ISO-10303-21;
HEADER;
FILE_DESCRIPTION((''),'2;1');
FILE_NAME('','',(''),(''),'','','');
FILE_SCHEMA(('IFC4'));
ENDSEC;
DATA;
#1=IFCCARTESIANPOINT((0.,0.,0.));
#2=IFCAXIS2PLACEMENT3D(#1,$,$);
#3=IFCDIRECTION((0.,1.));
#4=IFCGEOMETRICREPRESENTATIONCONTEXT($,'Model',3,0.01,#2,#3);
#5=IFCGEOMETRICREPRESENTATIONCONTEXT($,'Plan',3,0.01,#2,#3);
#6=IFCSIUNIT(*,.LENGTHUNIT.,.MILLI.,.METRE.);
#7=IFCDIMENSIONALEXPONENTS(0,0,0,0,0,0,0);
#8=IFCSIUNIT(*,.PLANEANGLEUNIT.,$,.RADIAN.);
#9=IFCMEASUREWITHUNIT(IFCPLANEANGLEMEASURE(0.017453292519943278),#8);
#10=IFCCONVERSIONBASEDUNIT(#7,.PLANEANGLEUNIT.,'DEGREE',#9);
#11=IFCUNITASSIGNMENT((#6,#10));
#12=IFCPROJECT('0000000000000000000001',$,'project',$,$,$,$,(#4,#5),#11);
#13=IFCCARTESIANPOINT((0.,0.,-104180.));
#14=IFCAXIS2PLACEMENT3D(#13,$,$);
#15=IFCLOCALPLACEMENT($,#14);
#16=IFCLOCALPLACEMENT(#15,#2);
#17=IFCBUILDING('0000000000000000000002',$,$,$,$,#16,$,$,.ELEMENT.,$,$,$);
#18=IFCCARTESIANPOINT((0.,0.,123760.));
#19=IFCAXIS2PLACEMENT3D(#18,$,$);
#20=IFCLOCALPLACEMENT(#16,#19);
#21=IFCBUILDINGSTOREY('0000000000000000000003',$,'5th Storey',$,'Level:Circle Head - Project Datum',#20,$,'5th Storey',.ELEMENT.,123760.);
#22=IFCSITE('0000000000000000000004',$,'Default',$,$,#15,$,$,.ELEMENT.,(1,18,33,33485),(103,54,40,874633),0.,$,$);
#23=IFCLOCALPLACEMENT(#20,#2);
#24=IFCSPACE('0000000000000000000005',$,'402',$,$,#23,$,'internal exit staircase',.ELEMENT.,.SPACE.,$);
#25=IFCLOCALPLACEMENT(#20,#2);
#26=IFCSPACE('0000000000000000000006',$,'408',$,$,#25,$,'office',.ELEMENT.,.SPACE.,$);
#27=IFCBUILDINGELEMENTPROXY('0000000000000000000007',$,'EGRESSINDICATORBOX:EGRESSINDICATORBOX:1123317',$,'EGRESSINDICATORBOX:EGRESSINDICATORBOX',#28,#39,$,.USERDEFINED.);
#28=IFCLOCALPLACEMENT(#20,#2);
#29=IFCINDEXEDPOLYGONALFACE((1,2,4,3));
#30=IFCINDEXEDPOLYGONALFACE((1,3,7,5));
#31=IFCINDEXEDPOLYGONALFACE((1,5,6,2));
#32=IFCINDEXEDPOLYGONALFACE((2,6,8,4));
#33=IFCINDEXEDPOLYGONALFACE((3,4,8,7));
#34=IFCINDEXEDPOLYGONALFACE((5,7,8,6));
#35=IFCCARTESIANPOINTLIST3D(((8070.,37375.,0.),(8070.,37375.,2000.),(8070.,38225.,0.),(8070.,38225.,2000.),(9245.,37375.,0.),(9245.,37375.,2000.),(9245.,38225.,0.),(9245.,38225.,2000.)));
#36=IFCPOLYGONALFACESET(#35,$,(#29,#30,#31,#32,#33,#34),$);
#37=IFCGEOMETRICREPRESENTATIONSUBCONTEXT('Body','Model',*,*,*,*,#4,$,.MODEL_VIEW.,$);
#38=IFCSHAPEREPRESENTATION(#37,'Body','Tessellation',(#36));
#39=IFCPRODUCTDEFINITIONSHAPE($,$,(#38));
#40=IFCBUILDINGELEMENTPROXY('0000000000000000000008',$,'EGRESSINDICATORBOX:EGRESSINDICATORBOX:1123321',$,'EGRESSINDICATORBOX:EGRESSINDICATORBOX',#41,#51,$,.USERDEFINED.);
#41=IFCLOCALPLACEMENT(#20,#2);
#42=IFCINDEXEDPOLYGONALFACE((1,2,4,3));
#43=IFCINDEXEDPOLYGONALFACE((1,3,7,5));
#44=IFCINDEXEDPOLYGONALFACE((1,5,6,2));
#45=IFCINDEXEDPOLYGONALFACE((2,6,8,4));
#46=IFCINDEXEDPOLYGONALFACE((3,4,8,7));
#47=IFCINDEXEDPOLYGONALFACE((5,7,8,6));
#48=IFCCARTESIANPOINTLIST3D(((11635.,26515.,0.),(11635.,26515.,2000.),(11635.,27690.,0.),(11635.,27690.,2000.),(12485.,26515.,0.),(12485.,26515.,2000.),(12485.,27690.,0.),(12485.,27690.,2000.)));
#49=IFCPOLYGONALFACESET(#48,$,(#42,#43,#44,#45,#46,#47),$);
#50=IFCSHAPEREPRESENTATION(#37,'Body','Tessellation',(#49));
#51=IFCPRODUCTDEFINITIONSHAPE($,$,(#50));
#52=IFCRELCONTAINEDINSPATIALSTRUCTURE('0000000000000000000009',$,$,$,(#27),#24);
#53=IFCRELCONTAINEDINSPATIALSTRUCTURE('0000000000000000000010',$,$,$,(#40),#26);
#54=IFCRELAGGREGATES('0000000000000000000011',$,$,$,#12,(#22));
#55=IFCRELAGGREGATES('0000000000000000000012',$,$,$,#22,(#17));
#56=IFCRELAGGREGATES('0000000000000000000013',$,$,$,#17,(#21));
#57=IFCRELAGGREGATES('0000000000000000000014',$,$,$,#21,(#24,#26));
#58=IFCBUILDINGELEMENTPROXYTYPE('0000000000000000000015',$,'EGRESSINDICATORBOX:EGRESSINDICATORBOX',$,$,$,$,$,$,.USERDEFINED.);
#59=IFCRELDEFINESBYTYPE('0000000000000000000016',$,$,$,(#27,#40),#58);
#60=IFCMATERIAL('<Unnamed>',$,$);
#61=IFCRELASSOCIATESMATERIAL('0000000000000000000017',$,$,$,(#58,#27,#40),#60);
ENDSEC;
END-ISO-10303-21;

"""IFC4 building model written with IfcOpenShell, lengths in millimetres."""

from ifc_helpers import new_model, entity, si_unit, converted_unit, direction, frame, origin, place, context, subcontext, project, spatial, indexed_curve, outline, extrude, source, transform, mapped, material, type_object, type_shapes, element, save


model = new_model("IFC4")

# Units and contexts
model_context = context("Model", 3, precision=0.01, world=origin(), true_north=direction((0.0, 1.0)))
plan_context = context("Plan", 3, precision=0.01, world=origin(), true_north=direction((0.0, 1.0)))
body_context = subcontext(model_context, "Body", "Model", "MODEL_VIEW")
ifc_project = project(units=[si_unit("LENGTHUNIT", "METRE", prefix="MILLI"), converted_unit("PLANEANGLEUNIT", "DEGREE", entity("IfcPlaneAngleMeasure", 0.017453292519943278), si_unit("PLANEANGLEUNIT", "RADIAN"), dimensions=[0, 0, 0, 0, 0, 0, 0])], contexts=[model_context, plan_context])

# Site, building, storey
site_placement = place(None, frame((0.0, 0.0, -104180.0)))
site = spatial("IfcSite", under=ifc_project, at=site_placement, Name="Default", CompositionType="ELEMENT", RefLatitude=(1, 18, 33, 33485), RefLongitude=(103, 54, 40, 874633), RefElevation=0.0)
building_placement = place(site_placement, origin())
building = spatial("IfcBuilding", under=site, at=building_placement, CompositionType="ELEMENT")
storey_placement = place(building_placement, frame((0.0, 0.0, 123760.0)))
storey = spatial("IfcBuildingStorey", under=building, at=storey_placement, Name="5th Storey", ObjectType="Level:Circle Head - Project Datum", LongName="5th Storey", CompositionType="ELEMENT", Elevation=123760.0)

# Shared definitions
ifc_material_1 = material(Name="<Unnamed>")

# Shared definitions
building_element_proxy_type_1 = type_object("IfcBuildingElementProxyType", Name="EGRESSINDICATORBOX:EGRESSINDICATORBOX", PredefinedType="USERDEFINED", material=ifc_material_1)
shared_shape_1 = source(origin(), body_context, "Body", "SweptSolid", [
    extrude(outline(indexed_curve([(-425.0, -587.5), (425.0, -587.5), (425.0, 587.5), (-425.0, 587.5), (-425.0, -587.5)], self_intersect=False)), frame((0.0, 0.0, 0.0), z_axis=(0.0, 0.0, 1.0), x_axis=(-1.0, 0.0, 0.0)), (0.0, 0.0, 1.0), 2000.0),
])
type_shapes(building_element_proxy_type_1, [shared_shape_1])

# Shared definitions
space_1_placement = place(storey_placement, origin())
space_1 = spatial("IfcSpace", under=storey, at=space_1_placement, Name="402", LongName="internal exit staircase", CompositionType="ELEMENT", PredefinedType="SPACE")

# Building element proxy
proxy_1_placement = place(space_1_placement, frame((8657.5, 37800.0, 0.0), z_axis=(0.0, 0.0, 1.0), x_axis=(0.0, 1.0, 0.0)))
element("IfcBuildingElementProxy", 1, at=proxy_1_placement, inside=space_1, type_object=building_element_proxy_type_1, material=ifc_material_1, Name="EGRESSINDICATORBOX:EGRESSINDICATORBOX:1123317", ObjectType="EGRESSINDICATORBOX:EGRESSINDICATORBOX", PredefinedType="USERDEFINED", context=body_context, shape_type="MappedRepresentation", body=[
    mapped(shared_shape_1, transform((0.0, 0.0, 0.0), scale=1.0)),
])

# Shared definitions
space_2_placement = place(storey_placement, origin())
space_2 = spatial("IfcSpace", under=storey, at=space_2_placement, Name="408", LongName="office", CompositionType="ELEMENT", PredefinedType="SPACE")

# Building element proxy
proxy_2_placement = place(space_2_placement, frame((12060.0, 27102.5, 0.0)))
element("IfcBuildingElementProxy", 2, at=proxy_2_placement, inside=space_2, type_object=building_element_proxy_type_1, material=ifc_material_1, Name="EGRESSINDICATORBOX:EGRESSINDICATORBOX:1123321", ObjectType="EGRESSINDICATORBOX:EGRESSINDICATORBOX", PredefinedType="USERDEFINED", context=body_context, shape_type="MappedRepresentation", body=[
    mapped(shared_shape_1, transform((0.0, 0.0, 0.0), scale=1.0)),
])

save(model, "model.ifc")
